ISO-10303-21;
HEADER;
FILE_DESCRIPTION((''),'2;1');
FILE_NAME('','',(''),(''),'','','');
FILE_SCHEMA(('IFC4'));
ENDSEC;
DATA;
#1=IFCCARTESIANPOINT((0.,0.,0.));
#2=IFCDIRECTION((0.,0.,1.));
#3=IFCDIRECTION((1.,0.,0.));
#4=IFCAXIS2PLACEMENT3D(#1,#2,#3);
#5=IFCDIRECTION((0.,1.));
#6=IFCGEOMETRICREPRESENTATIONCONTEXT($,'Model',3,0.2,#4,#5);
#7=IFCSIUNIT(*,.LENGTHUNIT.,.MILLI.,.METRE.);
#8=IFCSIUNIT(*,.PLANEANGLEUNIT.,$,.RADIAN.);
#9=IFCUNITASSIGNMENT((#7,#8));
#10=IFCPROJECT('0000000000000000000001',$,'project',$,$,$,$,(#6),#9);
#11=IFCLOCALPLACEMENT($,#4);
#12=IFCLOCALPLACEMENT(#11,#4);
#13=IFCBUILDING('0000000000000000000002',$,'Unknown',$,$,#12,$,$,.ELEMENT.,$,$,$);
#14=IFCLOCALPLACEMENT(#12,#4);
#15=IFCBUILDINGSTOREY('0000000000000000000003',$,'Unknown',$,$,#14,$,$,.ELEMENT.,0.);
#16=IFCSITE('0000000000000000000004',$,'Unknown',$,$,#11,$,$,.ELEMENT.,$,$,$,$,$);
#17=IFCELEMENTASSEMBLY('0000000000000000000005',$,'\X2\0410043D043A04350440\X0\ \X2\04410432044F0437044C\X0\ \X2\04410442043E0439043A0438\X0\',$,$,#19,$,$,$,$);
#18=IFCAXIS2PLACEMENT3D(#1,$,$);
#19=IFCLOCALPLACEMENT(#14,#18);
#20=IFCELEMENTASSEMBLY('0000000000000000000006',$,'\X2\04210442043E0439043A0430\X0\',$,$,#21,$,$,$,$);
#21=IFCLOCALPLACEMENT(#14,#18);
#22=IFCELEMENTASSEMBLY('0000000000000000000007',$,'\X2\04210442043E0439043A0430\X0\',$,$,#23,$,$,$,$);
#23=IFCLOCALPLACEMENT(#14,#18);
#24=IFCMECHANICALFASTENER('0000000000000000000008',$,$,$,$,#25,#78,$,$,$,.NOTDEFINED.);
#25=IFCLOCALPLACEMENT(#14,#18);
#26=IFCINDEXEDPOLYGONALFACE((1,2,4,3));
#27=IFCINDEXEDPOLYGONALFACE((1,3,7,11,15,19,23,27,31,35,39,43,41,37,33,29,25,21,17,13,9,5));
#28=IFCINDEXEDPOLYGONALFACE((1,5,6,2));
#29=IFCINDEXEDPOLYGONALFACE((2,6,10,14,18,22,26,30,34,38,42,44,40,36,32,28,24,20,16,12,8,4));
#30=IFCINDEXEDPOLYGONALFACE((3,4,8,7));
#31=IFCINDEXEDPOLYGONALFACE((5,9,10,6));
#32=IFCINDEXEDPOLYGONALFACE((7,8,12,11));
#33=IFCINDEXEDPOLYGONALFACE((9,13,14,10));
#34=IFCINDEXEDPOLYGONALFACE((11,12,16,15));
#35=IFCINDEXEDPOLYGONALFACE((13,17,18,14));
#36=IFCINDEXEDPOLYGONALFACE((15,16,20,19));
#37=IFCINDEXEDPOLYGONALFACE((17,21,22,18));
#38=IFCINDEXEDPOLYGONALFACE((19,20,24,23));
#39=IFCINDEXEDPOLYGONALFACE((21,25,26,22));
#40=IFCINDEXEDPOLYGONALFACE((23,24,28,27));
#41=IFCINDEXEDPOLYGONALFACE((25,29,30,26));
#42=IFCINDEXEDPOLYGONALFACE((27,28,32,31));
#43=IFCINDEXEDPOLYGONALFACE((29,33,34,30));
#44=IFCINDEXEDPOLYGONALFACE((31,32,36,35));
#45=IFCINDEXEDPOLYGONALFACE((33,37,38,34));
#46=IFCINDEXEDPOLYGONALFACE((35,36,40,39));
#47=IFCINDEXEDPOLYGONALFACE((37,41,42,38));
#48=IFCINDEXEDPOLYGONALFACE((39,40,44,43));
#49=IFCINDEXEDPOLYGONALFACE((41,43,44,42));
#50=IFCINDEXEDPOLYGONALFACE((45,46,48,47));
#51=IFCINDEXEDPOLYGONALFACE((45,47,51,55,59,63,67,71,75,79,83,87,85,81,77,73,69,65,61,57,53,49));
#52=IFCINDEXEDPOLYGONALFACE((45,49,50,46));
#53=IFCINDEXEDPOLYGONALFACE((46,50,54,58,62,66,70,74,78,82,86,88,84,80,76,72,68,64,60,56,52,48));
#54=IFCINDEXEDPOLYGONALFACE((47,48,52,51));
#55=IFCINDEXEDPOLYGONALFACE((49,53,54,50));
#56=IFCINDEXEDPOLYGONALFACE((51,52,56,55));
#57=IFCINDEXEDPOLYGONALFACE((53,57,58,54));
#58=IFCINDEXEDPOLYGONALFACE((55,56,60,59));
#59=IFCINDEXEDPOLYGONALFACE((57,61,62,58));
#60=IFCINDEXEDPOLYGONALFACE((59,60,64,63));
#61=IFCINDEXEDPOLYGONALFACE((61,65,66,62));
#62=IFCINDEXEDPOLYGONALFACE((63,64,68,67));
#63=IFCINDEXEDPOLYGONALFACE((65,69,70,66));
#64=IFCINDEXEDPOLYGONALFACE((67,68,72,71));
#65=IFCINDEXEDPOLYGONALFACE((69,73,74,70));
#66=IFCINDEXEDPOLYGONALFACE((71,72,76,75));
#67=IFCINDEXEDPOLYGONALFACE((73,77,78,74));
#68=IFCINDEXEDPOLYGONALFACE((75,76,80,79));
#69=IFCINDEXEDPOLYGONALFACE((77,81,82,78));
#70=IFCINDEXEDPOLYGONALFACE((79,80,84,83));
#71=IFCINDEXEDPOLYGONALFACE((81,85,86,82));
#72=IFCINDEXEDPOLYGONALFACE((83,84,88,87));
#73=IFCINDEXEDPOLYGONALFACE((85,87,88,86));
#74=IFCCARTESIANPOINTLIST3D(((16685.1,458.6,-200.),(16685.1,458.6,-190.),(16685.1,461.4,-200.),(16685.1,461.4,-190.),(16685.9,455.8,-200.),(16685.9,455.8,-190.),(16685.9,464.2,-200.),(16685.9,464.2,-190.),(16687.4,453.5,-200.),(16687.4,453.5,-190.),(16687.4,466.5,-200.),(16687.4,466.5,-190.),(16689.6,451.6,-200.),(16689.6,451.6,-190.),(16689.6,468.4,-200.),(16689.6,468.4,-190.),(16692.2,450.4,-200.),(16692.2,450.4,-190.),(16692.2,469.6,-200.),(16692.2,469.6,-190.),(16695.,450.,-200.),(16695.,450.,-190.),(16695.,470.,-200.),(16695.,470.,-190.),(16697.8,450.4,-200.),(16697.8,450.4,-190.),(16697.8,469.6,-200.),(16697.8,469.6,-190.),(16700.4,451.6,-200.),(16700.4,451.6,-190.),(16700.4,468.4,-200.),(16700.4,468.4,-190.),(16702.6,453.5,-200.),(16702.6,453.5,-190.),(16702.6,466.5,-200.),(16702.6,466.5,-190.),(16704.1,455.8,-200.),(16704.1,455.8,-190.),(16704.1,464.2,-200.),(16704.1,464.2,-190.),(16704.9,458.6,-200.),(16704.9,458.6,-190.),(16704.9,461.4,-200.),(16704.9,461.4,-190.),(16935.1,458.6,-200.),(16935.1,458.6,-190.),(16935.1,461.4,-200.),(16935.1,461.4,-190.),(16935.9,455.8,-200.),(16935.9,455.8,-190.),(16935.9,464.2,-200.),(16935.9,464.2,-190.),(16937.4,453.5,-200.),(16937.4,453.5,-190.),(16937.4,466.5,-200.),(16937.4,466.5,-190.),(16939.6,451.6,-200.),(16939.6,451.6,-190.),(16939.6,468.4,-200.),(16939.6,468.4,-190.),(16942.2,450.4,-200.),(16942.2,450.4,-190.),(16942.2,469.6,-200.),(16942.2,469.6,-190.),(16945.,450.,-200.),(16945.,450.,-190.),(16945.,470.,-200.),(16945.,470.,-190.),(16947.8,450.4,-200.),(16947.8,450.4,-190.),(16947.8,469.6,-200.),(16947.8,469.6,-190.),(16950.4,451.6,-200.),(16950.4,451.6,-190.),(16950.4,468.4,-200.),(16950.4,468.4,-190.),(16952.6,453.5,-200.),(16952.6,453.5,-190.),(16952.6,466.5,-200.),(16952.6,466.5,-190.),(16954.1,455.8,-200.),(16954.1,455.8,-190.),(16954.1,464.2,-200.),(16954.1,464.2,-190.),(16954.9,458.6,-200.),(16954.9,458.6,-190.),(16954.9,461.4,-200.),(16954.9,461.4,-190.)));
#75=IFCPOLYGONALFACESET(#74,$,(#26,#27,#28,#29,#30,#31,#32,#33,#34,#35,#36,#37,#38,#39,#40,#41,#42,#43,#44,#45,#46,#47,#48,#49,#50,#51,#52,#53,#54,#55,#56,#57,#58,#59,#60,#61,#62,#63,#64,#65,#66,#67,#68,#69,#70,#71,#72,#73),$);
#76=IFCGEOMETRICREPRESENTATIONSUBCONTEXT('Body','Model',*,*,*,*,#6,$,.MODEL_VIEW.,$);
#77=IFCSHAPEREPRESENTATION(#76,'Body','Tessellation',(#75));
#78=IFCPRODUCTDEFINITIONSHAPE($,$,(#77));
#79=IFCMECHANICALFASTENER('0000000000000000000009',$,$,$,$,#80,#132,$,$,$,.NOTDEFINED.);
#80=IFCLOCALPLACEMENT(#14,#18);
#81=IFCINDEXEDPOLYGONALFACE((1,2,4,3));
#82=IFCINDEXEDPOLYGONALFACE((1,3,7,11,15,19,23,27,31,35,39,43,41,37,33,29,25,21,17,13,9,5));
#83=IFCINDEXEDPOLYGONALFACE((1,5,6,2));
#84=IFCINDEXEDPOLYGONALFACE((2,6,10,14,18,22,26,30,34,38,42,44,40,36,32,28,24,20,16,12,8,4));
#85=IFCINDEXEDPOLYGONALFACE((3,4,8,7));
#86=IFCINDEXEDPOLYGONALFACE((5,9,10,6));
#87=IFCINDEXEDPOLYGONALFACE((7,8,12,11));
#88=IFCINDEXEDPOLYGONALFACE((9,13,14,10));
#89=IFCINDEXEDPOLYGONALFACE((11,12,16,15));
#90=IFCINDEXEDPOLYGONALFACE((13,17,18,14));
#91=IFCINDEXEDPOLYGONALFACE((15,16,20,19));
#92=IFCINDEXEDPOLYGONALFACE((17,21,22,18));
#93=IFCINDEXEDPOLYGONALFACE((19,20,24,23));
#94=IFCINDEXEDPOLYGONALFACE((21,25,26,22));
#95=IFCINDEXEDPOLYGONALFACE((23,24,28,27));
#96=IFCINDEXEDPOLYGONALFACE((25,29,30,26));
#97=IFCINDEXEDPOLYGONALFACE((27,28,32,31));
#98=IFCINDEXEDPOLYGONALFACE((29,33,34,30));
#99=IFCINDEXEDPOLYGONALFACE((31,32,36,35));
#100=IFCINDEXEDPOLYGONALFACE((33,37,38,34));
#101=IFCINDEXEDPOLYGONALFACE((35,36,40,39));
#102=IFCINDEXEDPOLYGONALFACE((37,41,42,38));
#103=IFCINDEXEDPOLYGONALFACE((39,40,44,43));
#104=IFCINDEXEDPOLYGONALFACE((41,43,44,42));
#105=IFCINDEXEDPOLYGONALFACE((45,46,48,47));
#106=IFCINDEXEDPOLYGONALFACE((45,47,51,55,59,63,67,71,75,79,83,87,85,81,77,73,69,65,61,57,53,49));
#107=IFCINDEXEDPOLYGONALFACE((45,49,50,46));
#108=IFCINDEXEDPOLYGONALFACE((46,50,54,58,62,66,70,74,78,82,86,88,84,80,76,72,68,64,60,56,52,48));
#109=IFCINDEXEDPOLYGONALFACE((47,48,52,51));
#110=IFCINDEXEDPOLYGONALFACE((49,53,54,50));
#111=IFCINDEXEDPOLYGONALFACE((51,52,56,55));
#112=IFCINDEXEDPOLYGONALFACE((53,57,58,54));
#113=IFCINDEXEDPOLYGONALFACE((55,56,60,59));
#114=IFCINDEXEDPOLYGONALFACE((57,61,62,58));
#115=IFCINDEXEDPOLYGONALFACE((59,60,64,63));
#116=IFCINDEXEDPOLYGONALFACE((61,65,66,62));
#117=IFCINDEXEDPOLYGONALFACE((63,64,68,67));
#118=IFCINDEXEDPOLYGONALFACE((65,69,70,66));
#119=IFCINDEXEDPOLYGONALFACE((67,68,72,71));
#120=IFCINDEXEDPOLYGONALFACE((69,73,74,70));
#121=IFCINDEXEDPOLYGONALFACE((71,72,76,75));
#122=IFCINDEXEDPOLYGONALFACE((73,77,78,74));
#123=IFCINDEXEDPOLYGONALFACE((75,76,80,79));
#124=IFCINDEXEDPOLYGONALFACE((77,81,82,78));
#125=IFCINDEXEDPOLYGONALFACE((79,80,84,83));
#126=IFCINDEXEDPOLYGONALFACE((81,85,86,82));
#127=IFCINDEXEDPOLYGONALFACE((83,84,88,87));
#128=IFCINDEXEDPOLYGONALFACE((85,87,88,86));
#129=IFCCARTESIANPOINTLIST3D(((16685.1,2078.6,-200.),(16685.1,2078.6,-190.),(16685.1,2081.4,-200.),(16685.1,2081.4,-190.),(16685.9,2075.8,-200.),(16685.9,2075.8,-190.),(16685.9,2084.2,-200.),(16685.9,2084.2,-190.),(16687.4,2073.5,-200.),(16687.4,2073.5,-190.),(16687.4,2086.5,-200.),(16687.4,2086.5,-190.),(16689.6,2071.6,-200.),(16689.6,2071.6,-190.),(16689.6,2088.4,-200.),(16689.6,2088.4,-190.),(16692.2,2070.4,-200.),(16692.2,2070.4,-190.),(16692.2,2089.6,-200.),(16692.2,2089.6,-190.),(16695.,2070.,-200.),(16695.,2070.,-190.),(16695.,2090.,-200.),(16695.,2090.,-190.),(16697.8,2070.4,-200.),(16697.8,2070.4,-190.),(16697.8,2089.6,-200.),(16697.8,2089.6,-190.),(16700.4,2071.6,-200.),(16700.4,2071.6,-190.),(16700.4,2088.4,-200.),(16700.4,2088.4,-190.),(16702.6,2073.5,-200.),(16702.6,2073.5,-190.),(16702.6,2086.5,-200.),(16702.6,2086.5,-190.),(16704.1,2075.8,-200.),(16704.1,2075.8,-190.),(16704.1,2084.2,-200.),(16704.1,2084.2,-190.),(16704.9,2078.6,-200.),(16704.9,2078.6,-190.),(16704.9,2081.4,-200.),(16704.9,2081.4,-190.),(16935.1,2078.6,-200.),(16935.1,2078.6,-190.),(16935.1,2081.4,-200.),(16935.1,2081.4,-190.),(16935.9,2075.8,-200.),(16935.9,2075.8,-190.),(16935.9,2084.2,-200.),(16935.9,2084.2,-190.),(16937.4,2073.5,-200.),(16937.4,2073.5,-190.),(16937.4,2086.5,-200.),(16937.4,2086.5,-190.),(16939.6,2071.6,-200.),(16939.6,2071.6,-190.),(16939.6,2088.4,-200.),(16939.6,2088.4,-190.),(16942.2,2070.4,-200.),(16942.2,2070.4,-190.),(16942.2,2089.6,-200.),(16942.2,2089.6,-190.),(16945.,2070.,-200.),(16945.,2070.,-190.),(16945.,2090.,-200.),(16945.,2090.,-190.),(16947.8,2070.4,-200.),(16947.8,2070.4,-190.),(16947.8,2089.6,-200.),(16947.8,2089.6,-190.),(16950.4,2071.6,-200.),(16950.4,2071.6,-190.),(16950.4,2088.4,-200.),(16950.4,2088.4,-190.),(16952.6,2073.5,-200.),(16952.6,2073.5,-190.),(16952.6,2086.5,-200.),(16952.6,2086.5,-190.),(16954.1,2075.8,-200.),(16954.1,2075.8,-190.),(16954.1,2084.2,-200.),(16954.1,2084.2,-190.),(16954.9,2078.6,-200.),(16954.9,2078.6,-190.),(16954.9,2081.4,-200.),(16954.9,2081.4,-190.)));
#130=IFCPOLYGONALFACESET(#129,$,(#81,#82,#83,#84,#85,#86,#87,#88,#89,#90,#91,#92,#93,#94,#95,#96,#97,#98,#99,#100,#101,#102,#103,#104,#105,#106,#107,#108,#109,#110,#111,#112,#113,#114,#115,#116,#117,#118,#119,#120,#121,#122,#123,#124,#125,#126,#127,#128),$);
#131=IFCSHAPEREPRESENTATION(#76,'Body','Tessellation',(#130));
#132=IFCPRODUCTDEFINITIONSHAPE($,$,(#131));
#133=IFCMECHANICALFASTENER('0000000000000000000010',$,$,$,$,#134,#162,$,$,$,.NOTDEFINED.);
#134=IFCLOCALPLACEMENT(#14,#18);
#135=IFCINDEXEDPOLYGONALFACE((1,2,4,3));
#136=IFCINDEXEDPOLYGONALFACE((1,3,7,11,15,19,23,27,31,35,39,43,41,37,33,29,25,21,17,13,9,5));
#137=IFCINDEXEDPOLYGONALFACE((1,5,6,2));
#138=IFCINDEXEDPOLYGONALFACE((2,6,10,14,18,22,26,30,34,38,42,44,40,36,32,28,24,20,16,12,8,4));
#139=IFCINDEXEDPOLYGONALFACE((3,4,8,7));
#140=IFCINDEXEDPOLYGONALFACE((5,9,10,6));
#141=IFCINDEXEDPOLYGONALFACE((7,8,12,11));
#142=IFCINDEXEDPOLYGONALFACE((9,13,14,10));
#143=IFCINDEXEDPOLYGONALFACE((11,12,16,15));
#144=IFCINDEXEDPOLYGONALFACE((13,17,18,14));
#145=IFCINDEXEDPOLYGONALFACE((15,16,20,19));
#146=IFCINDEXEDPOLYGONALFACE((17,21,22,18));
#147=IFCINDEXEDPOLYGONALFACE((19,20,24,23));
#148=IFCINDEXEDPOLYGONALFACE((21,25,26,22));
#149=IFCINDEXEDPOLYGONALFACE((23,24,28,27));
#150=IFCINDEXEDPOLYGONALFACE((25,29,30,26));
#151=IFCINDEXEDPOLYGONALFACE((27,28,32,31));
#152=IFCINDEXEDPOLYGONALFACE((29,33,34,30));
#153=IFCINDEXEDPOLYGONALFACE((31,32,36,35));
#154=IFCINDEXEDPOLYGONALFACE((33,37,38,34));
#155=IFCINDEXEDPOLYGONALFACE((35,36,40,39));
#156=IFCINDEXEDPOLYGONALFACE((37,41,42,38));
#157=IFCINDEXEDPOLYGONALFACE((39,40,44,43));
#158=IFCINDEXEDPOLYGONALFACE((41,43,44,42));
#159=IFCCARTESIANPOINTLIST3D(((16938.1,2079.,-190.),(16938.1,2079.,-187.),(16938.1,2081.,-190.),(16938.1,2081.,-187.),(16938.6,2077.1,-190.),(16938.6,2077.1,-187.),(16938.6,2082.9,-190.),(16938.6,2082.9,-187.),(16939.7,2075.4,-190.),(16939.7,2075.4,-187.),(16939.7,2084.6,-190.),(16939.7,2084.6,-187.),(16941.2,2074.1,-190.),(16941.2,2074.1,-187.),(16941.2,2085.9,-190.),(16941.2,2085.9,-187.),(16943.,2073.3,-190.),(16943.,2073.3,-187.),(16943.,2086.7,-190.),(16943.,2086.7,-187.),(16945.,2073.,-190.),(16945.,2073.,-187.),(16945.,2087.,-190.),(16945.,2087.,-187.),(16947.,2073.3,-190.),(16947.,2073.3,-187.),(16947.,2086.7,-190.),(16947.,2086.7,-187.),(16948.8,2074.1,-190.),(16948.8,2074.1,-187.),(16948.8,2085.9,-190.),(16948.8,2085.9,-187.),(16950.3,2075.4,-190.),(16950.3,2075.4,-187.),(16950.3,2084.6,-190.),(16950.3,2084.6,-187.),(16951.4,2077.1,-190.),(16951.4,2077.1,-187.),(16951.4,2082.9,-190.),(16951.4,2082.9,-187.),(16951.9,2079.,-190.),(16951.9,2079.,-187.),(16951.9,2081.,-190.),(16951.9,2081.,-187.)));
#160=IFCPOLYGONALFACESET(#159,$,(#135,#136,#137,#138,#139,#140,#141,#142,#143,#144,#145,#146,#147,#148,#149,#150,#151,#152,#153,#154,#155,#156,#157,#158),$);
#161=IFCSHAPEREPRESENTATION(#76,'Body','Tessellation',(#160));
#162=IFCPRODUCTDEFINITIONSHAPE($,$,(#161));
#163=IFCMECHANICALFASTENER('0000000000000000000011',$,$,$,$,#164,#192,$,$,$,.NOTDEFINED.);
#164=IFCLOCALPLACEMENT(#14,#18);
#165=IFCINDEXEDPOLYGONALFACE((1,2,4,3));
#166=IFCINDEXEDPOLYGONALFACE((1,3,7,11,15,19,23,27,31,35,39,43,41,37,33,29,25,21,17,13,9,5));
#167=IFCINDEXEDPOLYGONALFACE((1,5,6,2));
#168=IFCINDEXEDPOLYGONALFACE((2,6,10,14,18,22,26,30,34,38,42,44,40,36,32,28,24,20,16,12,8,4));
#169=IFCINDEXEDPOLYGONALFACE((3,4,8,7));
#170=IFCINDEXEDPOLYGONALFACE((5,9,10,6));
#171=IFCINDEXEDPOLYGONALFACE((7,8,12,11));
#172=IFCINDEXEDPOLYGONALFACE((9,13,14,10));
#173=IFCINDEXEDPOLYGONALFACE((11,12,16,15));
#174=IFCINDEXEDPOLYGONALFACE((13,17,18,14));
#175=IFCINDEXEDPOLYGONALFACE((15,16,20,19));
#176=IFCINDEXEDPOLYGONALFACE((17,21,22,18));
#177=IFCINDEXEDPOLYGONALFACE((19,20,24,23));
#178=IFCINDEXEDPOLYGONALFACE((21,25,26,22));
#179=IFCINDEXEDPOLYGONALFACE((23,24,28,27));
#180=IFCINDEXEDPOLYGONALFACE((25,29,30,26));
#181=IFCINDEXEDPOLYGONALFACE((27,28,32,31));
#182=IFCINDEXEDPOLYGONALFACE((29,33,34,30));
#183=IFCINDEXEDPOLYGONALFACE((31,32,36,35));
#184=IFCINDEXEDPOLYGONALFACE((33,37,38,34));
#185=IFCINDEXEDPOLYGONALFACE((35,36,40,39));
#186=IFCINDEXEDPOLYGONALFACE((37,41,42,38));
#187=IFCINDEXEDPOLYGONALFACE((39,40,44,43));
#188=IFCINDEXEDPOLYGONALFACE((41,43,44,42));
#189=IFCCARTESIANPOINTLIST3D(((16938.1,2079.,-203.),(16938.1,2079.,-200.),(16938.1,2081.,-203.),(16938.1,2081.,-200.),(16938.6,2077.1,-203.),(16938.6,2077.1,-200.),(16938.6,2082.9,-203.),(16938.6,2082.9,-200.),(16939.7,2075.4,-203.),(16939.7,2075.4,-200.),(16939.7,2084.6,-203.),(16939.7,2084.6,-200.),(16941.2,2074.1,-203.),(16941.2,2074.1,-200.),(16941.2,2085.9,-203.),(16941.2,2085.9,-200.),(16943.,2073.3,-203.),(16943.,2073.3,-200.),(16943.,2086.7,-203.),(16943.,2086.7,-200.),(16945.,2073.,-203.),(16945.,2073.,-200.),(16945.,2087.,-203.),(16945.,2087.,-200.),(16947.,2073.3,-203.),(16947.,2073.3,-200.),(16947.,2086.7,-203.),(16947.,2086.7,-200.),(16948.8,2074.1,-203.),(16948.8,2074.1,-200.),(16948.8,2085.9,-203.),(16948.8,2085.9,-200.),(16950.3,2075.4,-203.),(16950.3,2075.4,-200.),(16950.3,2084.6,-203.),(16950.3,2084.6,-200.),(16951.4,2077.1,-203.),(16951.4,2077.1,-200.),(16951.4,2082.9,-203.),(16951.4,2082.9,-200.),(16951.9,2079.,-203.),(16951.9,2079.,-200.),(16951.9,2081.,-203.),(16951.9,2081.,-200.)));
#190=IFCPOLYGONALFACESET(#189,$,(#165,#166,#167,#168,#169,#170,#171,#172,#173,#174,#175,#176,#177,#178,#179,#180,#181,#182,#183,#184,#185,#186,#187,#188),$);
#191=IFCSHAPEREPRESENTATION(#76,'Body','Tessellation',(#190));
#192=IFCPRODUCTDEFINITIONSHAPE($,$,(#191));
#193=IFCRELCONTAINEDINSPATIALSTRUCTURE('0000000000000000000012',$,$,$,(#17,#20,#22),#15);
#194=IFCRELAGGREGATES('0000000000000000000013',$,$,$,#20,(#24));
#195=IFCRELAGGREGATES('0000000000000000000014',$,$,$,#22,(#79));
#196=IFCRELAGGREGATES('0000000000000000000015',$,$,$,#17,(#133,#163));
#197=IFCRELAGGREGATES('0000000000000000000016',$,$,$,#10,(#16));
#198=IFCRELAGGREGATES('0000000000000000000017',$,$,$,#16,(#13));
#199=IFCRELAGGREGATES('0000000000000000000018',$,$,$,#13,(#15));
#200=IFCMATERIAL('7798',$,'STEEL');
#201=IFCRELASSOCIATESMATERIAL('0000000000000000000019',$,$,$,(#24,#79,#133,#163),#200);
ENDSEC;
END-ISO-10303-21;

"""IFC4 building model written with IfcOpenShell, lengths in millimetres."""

from ifc_helpers import new_model, si_unit, direction, frame, origin_with_axes, place, context, subcontext, project, spatial, arc, indexed_curve, outline, extrude, source, transform, mapped, material, element, aggregate, save


model = new_model("IFC4")

# Units and contexts
model_context = context("Model", 3, precision=0.2, world=origin_with_axes(), true_north=direction((0.0, 1.0)))
body_context = subcontext(model_context, "Body", "Model", "MODEL_VIEW")
ifc_project = project(units=[si_unit("LENGTHUNIT", "METRE", prefix="MILLI"), si_unit("PLANEANGLEUNIT", "RADIAN")], contexts=[model_context])

# Site, building, storey
site_placement = place(None, origin_with_axes())
site = spatial("IfcSite", under=ifc_project, at=site_placement, Name="Unknown", CompositionType="ELEMENT")
building_placement = place(site_placement, origin_with_axes())
building = spatial("IfcBuilding", under=site, at=building_placement, Name="Unknown", CompositionType="ELEMENT")
storey_placement = place(building_placement, origin_with_axes())
storey = spatial("IfcBuildingStorey", under=building, at=storey_placement, Name="Unknown", CompositionType="ELEMENT", Elevation=0.0)

# Element assembly
assembly_1_placement = place(storey_placement, frame((16945.0, 2080.0, -160.0), z_axis=(0.0, -1.0, 0.0), x_axis=(0.0, 0.0, -1.0)))
assembly_1 = element("IfcElementAssembly", 1, at=assembly_1_placement, inside=storey, Name="Анкер связь стойки")

# Element assemblies
assembly_2_placement = place(storey_placement, frame((16820.0, 460.0, 0.0), z_axis=(0.0, -1.0, 0.0), x_axis=(0.0, 0.0, 1.0)))
assembly_2 = element("IfcElementAssembly", 2, at=assembly_2_placement, inside=storey, Name="Стойка")
assembly_3_placement = place(storey_placement, frame((16820.0, 2080.0, 0.0), z_axis=(0.0, -1.0, 0.0), x_axis=(0.0, 0.0, 1.0)))
assembly_3 = element("IfcElementAssembly", 3, at=assembly_3_placement, inside=storey, Name="Стойка")

# Mechanical fasteners
ifc_material_1 = material(Name="7798", Category="STEEL")
shared_shape_1 = source(origin_with_axes(), body_context, "Body", "SweptSolid", [
    extrude(outline(indexed_curve([(10.0, 0.0), (0.0, 10.0), (-10.0, 0.0), (0.0, -10.0)], segments=[arc(1, 2, 3), arc(3, 4, 1)])), frame((0.0, 0.0, 10.0), z_axis=(0.0, 0.0, -1.0), x_axis=(0.0, 1.0, 0.0)), (0.0, 0.0, 1.0), 10.0),
])
mechanical_fastener_1_placement = place(assembly_2_placement, frame((-190.0, 60.0, 0.0), z_axis=(-1.0, 0.0, 0.0), x_axis=(0.0, -1.0, 0.0)))
mechanical_fastener_1 = element("IfcMechanicalFastener", 4, at=mechanical_fastener_1_placement, material=ifc_material_1, PredefinedType="NOTDEFINED", context=body_context, shape_type="MappedRepresentation", body=[
    mapped(shared_shape_1, transform((-65.0, 0.0, 0.0))),
    mapped(shared_shape_1, transform((185.0, 0.0, 0.0))),
])
aggregate(assembly_2, [mechanical_fastener_1])
mechanical_fastener_2_placement = place(assembly_3_placement, frame((-190.0, 60.0, 0.0), z_axis=(-1.0, 0.0, 0.0), x_axis=(0.0, -1.0, 0.0)))
mechanical_fastener_2 = element("IfcMechanicalFastener", 5, at=mechanical_fastener_2_placement, material=ifc_material_1, PredefinedType="NOTDEFINED", context=body_context, shape_type="MappedRepresentation", body=[
    mapped(shared_shape_1, transform((-65.0, 0.0, 0.0))),
    mapped(shared_shape_1, transform((185.0, 0.0, 0.0))),
])
aggregate(assembly_3, [mechanical_fastener_2])
shared_shape_2 = source(origin_with_axes(), body_context, "Body", "SweptSolid", [
    extrude(outline(indexed_curve([(7.0, 0.0), (0.0, 7.0), (-7.0, 0.0), (0.0, -7.0)], segments=[arc(1, 2, 3), arc(3, 4, 1)])), frame((0.0, 0.0, 3.0), z_axis=(0.0, 0.0, -1.0), x_axis=(0.0, 1.0, 0.0)), (0.0, 0.0, 1.0), 3.0),
])
mechanical_fastener_3_placement = place(assembly_1_placement, frame((27.0, 0.0, 0.0), z_axis=(1.0, 0.0, 0.0), x_axis=(0.0, -1.0, 0.0)))
mechanical_fastener_3 = element("IfcMechanicalFastener", 6, at=mechanical_fastener_3_placement, material=ifc_material_1, PredefinedType="NOTDEFINED", context=body_context, shape_type="MappedRepresentation", body=[
    mapped(shared_shape_2, transform((0.0, 0.0, 0.0))),
])
mechanical_fastener_4_placement = place(assembly_1_placement, frame((40.0, 0.0, 0.0), z_axis=(1.0, 0.0, 0.0), x_axis=(0.0, -1.0, 0.0)))
mechanical_fastener_4 = element("IfcMechanicalFastener", 7, at=mechanical_fastener_4_placement, material=ifc_material_1, PredefinedType="NOTDEFINED", context=body_context, shape_type="MappedRepresentation", body=[
    mapped(shared_shape_2, transform((0.0, 0.0, 0.0))),
])
aggregate(assembly_1, [mechanical_fastener_3, mechanical_fastener_4])

save(model, "model.ifc")
